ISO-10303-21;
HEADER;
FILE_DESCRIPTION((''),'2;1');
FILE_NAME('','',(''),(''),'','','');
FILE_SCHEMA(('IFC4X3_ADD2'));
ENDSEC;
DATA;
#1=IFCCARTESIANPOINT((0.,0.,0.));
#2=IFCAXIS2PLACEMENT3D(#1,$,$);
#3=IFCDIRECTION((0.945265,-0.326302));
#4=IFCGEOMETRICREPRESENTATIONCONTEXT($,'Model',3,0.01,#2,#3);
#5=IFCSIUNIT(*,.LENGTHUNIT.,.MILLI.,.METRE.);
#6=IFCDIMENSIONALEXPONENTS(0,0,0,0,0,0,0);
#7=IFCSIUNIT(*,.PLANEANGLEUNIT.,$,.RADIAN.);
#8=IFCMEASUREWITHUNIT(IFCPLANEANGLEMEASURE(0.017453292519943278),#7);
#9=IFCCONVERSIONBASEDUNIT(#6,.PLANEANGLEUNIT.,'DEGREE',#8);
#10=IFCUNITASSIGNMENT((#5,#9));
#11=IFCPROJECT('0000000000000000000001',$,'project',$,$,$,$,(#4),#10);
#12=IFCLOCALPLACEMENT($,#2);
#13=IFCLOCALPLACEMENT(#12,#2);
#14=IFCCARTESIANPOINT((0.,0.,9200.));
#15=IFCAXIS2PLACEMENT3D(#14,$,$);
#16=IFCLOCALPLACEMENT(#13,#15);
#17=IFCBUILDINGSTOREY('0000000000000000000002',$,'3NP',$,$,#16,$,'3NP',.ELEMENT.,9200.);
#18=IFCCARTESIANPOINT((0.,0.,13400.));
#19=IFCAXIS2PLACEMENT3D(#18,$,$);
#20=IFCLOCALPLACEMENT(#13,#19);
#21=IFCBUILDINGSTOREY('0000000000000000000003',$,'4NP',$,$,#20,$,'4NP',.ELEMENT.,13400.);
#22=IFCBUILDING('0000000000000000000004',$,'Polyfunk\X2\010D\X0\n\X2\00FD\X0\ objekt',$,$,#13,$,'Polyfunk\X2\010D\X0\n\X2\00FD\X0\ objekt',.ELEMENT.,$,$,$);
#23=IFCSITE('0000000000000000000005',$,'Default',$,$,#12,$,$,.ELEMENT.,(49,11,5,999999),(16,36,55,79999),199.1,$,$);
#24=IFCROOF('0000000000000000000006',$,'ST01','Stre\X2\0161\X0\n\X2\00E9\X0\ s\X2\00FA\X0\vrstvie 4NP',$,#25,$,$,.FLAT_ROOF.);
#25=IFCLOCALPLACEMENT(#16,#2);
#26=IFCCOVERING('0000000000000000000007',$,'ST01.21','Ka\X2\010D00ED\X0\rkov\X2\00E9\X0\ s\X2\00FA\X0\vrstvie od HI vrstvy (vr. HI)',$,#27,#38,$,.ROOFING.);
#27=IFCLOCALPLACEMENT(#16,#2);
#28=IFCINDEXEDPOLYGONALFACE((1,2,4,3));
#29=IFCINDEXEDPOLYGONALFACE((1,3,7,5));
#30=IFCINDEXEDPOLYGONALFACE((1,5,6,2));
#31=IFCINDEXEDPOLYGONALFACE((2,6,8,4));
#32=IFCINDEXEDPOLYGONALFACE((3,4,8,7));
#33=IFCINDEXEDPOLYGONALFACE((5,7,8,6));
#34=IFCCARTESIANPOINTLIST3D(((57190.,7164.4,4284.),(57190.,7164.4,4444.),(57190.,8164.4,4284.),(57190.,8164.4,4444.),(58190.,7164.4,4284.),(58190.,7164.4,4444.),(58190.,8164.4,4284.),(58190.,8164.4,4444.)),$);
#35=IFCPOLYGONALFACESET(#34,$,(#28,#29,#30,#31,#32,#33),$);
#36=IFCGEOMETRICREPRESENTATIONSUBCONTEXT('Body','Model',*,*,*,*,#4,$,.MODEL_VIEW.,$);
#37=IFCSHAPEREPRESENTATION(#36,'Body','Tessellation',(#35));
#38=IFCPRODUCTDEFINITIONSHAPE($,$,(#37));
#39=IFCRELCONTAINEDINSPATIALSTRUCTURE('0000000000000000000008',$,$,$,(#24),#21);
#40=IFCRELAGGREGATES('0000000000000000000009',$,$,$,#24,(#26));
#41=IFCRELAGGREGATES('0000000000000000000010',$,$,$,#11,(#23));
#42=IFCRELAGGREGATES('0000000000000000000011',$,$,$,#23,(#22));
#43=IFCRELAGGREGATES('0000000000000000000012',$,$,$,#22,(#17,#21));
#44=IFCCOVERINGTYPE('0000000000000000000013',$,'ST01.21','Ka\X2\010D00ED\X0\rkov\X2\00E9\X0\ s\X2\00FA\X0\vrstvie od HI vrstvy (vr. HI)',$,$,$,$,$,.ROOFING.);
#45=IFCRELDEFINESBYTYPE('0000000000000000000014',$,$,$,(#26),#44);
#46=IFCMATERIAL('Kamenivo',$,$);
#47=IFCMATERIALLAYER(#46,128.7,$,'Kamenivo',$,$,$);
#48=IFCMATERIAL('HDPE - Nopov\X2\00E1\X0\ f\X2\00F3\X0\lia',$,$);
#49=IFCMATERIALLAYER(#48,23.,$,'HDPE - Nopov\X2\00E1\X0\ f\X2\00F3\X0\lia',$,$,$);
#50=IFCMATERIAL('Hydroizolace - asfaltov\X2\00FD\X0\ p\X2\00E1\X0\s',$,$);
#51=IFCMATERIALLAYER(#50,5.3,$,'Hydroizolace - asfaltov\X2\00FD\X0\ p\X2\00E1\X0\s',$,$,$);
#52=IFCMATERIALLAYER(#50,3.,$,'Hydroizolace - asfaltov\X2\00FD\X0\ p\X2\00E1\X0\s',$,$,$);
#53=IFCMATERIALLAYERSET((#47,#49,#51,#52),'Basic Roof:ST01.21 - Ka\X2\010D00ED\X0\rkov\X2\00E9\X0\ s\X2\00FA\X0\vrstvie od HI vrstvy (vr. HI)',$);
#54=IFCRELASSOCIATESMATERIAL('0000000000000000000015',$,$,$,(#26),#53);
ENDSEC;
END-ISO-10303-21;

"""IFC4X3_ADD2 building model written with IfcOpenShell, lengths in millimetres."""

from ifc_helpers import new_model, entity, si_unit, converted_unit, direction, frame, frame_2d, origin, place, context, subcontext, project, spatial, rectangle, extrude, material, layer, layer_set, type_object, element, aggregate, save


model = new_model("IFC4X3_ADD2")

# Units and contexts
model_context = context("Model", 3, precision=0.01, world=origin(), true_north=direction((0.945265, -0.326302)))
body_context = subcontext(model_context, "Body", "Model", "MODEL_VIEW")
ifc_project = project(units=[si_unit("LENGTHUNIT", "METRE", prefix="MILLI"), converted_unit("PLANEANGLEUNIT", "DEGREE", entity("IfcPlaneAngleMeasure", 0.017453292519943278), si_unit("PLANEANGLEUNIT", "RADIAN"), dimensions=[0, 0, 0, 0, 0, 0, 0])], contexts=[model_context])

# Site, building, storey
site_placement = place(None, origin())
site = spatial("IfcSite", under=ifc_project, at=site_placement, Name="Default", CompositionType="ELEMENT", RefLatitude=(49, 11, 5, 999999), RefLongitude=(16, 36, 55, 79999), RefElevation=199.1)
building_placement = place(site_placement, origin())
building = spatial("IfcBuilding", under=site, at=building_placement, Name="Polyfunkčný objekt", LongName="Polyfunkčný objekt", CompositionType="ELEMENT")
storey_1_placement = place(building_placement, frame((0.0, 0.0, 9200.0)))
storey_1 = spatial("IfcBuildingStorey", under=building, at=storey_1_placement, Name="3NP", LongName="3NP", CompositionType="ELEMENT", Elevation=9200.0)

# Shared definitions
storey_2_placement = place(building_placement, frame((0.0, 0.0, 13400.0)))
storey_2 = spatial("IfcBuildingStorey", under=building, at=storey_2_placement, Name="4NP", LongName="4NP", CompositionType="ELEMENT", Elevation=13400.0)

# Roof, covering
roof = element("IfcRoof", 1, inside=storey_2, Name="ST01", Description="Strešné súvrstvie 4NP", PredefinedType="FLAT_ROOF")
ifc_material_1 = material(Name="HDPE - Nopová fólia")
ifc_material_2 = material(Name="Hydroizolace - asfaltový pás")
ifc_material_3 = material(Name="Kamenivo")
ifc_layer_1 = layer(ifc_material_3, 128.7, Name="Kamenivo")
ifc_layer_2 = layer(ifc_material_1, 23.0, Name="HDPE - Nopová fólia")
ifc_layer_3 = layer(ifc_material_2, 5.3, Name="Hydroizolace - asfaltový pás")
ifc_layer_4 = layer(ifc_material_2, 3.0, Name="Hydroizolace - asfaltový pás")
ifc_layer_set_1 = layer_set([ifc_layer_1, ifc_layer_2, ifc_layer_3, ifc_layer_4], Name="Basic Roof:ST01.21 - Kačírkové súvrstvie od HI vrstvy (vr. HI)")
covering_type_1 = type_object("IfcCoveringType", Name="ST01.21", Description="Kačírkové súvrstvie od HI vrstvy (vr. HI)", PredefinedType="ROOFING")
placement_1 = place(storey_2_placement, frame((57190.0, 7164.4, 84.0)))
covering_1_placement = place(placement_1, origin())
covering_1 = element("IfcCovering", 2, at=covering_1_placement, type_object=covering_type_1, material=ifc_layer_set_1, Name="ST01.21", Description="Kačírkové súvrstvie od HI vrstvy (vr. HI)", PredefinedType="ROOFING", context=body_context, shape_type="SweptSolid", body=[
    extrude(rectangle(XDim=1000.0, YDim=1000.0, at=frame_2d((0.0, 0.0), x_axis=(1.0, 0.0))), frame((500.0, 500.0, 0.0)), (0.0, 0.0, 1.0), 160.0),
])
aggregate(roof, [covering_1])

save(model, "model.ifc")
